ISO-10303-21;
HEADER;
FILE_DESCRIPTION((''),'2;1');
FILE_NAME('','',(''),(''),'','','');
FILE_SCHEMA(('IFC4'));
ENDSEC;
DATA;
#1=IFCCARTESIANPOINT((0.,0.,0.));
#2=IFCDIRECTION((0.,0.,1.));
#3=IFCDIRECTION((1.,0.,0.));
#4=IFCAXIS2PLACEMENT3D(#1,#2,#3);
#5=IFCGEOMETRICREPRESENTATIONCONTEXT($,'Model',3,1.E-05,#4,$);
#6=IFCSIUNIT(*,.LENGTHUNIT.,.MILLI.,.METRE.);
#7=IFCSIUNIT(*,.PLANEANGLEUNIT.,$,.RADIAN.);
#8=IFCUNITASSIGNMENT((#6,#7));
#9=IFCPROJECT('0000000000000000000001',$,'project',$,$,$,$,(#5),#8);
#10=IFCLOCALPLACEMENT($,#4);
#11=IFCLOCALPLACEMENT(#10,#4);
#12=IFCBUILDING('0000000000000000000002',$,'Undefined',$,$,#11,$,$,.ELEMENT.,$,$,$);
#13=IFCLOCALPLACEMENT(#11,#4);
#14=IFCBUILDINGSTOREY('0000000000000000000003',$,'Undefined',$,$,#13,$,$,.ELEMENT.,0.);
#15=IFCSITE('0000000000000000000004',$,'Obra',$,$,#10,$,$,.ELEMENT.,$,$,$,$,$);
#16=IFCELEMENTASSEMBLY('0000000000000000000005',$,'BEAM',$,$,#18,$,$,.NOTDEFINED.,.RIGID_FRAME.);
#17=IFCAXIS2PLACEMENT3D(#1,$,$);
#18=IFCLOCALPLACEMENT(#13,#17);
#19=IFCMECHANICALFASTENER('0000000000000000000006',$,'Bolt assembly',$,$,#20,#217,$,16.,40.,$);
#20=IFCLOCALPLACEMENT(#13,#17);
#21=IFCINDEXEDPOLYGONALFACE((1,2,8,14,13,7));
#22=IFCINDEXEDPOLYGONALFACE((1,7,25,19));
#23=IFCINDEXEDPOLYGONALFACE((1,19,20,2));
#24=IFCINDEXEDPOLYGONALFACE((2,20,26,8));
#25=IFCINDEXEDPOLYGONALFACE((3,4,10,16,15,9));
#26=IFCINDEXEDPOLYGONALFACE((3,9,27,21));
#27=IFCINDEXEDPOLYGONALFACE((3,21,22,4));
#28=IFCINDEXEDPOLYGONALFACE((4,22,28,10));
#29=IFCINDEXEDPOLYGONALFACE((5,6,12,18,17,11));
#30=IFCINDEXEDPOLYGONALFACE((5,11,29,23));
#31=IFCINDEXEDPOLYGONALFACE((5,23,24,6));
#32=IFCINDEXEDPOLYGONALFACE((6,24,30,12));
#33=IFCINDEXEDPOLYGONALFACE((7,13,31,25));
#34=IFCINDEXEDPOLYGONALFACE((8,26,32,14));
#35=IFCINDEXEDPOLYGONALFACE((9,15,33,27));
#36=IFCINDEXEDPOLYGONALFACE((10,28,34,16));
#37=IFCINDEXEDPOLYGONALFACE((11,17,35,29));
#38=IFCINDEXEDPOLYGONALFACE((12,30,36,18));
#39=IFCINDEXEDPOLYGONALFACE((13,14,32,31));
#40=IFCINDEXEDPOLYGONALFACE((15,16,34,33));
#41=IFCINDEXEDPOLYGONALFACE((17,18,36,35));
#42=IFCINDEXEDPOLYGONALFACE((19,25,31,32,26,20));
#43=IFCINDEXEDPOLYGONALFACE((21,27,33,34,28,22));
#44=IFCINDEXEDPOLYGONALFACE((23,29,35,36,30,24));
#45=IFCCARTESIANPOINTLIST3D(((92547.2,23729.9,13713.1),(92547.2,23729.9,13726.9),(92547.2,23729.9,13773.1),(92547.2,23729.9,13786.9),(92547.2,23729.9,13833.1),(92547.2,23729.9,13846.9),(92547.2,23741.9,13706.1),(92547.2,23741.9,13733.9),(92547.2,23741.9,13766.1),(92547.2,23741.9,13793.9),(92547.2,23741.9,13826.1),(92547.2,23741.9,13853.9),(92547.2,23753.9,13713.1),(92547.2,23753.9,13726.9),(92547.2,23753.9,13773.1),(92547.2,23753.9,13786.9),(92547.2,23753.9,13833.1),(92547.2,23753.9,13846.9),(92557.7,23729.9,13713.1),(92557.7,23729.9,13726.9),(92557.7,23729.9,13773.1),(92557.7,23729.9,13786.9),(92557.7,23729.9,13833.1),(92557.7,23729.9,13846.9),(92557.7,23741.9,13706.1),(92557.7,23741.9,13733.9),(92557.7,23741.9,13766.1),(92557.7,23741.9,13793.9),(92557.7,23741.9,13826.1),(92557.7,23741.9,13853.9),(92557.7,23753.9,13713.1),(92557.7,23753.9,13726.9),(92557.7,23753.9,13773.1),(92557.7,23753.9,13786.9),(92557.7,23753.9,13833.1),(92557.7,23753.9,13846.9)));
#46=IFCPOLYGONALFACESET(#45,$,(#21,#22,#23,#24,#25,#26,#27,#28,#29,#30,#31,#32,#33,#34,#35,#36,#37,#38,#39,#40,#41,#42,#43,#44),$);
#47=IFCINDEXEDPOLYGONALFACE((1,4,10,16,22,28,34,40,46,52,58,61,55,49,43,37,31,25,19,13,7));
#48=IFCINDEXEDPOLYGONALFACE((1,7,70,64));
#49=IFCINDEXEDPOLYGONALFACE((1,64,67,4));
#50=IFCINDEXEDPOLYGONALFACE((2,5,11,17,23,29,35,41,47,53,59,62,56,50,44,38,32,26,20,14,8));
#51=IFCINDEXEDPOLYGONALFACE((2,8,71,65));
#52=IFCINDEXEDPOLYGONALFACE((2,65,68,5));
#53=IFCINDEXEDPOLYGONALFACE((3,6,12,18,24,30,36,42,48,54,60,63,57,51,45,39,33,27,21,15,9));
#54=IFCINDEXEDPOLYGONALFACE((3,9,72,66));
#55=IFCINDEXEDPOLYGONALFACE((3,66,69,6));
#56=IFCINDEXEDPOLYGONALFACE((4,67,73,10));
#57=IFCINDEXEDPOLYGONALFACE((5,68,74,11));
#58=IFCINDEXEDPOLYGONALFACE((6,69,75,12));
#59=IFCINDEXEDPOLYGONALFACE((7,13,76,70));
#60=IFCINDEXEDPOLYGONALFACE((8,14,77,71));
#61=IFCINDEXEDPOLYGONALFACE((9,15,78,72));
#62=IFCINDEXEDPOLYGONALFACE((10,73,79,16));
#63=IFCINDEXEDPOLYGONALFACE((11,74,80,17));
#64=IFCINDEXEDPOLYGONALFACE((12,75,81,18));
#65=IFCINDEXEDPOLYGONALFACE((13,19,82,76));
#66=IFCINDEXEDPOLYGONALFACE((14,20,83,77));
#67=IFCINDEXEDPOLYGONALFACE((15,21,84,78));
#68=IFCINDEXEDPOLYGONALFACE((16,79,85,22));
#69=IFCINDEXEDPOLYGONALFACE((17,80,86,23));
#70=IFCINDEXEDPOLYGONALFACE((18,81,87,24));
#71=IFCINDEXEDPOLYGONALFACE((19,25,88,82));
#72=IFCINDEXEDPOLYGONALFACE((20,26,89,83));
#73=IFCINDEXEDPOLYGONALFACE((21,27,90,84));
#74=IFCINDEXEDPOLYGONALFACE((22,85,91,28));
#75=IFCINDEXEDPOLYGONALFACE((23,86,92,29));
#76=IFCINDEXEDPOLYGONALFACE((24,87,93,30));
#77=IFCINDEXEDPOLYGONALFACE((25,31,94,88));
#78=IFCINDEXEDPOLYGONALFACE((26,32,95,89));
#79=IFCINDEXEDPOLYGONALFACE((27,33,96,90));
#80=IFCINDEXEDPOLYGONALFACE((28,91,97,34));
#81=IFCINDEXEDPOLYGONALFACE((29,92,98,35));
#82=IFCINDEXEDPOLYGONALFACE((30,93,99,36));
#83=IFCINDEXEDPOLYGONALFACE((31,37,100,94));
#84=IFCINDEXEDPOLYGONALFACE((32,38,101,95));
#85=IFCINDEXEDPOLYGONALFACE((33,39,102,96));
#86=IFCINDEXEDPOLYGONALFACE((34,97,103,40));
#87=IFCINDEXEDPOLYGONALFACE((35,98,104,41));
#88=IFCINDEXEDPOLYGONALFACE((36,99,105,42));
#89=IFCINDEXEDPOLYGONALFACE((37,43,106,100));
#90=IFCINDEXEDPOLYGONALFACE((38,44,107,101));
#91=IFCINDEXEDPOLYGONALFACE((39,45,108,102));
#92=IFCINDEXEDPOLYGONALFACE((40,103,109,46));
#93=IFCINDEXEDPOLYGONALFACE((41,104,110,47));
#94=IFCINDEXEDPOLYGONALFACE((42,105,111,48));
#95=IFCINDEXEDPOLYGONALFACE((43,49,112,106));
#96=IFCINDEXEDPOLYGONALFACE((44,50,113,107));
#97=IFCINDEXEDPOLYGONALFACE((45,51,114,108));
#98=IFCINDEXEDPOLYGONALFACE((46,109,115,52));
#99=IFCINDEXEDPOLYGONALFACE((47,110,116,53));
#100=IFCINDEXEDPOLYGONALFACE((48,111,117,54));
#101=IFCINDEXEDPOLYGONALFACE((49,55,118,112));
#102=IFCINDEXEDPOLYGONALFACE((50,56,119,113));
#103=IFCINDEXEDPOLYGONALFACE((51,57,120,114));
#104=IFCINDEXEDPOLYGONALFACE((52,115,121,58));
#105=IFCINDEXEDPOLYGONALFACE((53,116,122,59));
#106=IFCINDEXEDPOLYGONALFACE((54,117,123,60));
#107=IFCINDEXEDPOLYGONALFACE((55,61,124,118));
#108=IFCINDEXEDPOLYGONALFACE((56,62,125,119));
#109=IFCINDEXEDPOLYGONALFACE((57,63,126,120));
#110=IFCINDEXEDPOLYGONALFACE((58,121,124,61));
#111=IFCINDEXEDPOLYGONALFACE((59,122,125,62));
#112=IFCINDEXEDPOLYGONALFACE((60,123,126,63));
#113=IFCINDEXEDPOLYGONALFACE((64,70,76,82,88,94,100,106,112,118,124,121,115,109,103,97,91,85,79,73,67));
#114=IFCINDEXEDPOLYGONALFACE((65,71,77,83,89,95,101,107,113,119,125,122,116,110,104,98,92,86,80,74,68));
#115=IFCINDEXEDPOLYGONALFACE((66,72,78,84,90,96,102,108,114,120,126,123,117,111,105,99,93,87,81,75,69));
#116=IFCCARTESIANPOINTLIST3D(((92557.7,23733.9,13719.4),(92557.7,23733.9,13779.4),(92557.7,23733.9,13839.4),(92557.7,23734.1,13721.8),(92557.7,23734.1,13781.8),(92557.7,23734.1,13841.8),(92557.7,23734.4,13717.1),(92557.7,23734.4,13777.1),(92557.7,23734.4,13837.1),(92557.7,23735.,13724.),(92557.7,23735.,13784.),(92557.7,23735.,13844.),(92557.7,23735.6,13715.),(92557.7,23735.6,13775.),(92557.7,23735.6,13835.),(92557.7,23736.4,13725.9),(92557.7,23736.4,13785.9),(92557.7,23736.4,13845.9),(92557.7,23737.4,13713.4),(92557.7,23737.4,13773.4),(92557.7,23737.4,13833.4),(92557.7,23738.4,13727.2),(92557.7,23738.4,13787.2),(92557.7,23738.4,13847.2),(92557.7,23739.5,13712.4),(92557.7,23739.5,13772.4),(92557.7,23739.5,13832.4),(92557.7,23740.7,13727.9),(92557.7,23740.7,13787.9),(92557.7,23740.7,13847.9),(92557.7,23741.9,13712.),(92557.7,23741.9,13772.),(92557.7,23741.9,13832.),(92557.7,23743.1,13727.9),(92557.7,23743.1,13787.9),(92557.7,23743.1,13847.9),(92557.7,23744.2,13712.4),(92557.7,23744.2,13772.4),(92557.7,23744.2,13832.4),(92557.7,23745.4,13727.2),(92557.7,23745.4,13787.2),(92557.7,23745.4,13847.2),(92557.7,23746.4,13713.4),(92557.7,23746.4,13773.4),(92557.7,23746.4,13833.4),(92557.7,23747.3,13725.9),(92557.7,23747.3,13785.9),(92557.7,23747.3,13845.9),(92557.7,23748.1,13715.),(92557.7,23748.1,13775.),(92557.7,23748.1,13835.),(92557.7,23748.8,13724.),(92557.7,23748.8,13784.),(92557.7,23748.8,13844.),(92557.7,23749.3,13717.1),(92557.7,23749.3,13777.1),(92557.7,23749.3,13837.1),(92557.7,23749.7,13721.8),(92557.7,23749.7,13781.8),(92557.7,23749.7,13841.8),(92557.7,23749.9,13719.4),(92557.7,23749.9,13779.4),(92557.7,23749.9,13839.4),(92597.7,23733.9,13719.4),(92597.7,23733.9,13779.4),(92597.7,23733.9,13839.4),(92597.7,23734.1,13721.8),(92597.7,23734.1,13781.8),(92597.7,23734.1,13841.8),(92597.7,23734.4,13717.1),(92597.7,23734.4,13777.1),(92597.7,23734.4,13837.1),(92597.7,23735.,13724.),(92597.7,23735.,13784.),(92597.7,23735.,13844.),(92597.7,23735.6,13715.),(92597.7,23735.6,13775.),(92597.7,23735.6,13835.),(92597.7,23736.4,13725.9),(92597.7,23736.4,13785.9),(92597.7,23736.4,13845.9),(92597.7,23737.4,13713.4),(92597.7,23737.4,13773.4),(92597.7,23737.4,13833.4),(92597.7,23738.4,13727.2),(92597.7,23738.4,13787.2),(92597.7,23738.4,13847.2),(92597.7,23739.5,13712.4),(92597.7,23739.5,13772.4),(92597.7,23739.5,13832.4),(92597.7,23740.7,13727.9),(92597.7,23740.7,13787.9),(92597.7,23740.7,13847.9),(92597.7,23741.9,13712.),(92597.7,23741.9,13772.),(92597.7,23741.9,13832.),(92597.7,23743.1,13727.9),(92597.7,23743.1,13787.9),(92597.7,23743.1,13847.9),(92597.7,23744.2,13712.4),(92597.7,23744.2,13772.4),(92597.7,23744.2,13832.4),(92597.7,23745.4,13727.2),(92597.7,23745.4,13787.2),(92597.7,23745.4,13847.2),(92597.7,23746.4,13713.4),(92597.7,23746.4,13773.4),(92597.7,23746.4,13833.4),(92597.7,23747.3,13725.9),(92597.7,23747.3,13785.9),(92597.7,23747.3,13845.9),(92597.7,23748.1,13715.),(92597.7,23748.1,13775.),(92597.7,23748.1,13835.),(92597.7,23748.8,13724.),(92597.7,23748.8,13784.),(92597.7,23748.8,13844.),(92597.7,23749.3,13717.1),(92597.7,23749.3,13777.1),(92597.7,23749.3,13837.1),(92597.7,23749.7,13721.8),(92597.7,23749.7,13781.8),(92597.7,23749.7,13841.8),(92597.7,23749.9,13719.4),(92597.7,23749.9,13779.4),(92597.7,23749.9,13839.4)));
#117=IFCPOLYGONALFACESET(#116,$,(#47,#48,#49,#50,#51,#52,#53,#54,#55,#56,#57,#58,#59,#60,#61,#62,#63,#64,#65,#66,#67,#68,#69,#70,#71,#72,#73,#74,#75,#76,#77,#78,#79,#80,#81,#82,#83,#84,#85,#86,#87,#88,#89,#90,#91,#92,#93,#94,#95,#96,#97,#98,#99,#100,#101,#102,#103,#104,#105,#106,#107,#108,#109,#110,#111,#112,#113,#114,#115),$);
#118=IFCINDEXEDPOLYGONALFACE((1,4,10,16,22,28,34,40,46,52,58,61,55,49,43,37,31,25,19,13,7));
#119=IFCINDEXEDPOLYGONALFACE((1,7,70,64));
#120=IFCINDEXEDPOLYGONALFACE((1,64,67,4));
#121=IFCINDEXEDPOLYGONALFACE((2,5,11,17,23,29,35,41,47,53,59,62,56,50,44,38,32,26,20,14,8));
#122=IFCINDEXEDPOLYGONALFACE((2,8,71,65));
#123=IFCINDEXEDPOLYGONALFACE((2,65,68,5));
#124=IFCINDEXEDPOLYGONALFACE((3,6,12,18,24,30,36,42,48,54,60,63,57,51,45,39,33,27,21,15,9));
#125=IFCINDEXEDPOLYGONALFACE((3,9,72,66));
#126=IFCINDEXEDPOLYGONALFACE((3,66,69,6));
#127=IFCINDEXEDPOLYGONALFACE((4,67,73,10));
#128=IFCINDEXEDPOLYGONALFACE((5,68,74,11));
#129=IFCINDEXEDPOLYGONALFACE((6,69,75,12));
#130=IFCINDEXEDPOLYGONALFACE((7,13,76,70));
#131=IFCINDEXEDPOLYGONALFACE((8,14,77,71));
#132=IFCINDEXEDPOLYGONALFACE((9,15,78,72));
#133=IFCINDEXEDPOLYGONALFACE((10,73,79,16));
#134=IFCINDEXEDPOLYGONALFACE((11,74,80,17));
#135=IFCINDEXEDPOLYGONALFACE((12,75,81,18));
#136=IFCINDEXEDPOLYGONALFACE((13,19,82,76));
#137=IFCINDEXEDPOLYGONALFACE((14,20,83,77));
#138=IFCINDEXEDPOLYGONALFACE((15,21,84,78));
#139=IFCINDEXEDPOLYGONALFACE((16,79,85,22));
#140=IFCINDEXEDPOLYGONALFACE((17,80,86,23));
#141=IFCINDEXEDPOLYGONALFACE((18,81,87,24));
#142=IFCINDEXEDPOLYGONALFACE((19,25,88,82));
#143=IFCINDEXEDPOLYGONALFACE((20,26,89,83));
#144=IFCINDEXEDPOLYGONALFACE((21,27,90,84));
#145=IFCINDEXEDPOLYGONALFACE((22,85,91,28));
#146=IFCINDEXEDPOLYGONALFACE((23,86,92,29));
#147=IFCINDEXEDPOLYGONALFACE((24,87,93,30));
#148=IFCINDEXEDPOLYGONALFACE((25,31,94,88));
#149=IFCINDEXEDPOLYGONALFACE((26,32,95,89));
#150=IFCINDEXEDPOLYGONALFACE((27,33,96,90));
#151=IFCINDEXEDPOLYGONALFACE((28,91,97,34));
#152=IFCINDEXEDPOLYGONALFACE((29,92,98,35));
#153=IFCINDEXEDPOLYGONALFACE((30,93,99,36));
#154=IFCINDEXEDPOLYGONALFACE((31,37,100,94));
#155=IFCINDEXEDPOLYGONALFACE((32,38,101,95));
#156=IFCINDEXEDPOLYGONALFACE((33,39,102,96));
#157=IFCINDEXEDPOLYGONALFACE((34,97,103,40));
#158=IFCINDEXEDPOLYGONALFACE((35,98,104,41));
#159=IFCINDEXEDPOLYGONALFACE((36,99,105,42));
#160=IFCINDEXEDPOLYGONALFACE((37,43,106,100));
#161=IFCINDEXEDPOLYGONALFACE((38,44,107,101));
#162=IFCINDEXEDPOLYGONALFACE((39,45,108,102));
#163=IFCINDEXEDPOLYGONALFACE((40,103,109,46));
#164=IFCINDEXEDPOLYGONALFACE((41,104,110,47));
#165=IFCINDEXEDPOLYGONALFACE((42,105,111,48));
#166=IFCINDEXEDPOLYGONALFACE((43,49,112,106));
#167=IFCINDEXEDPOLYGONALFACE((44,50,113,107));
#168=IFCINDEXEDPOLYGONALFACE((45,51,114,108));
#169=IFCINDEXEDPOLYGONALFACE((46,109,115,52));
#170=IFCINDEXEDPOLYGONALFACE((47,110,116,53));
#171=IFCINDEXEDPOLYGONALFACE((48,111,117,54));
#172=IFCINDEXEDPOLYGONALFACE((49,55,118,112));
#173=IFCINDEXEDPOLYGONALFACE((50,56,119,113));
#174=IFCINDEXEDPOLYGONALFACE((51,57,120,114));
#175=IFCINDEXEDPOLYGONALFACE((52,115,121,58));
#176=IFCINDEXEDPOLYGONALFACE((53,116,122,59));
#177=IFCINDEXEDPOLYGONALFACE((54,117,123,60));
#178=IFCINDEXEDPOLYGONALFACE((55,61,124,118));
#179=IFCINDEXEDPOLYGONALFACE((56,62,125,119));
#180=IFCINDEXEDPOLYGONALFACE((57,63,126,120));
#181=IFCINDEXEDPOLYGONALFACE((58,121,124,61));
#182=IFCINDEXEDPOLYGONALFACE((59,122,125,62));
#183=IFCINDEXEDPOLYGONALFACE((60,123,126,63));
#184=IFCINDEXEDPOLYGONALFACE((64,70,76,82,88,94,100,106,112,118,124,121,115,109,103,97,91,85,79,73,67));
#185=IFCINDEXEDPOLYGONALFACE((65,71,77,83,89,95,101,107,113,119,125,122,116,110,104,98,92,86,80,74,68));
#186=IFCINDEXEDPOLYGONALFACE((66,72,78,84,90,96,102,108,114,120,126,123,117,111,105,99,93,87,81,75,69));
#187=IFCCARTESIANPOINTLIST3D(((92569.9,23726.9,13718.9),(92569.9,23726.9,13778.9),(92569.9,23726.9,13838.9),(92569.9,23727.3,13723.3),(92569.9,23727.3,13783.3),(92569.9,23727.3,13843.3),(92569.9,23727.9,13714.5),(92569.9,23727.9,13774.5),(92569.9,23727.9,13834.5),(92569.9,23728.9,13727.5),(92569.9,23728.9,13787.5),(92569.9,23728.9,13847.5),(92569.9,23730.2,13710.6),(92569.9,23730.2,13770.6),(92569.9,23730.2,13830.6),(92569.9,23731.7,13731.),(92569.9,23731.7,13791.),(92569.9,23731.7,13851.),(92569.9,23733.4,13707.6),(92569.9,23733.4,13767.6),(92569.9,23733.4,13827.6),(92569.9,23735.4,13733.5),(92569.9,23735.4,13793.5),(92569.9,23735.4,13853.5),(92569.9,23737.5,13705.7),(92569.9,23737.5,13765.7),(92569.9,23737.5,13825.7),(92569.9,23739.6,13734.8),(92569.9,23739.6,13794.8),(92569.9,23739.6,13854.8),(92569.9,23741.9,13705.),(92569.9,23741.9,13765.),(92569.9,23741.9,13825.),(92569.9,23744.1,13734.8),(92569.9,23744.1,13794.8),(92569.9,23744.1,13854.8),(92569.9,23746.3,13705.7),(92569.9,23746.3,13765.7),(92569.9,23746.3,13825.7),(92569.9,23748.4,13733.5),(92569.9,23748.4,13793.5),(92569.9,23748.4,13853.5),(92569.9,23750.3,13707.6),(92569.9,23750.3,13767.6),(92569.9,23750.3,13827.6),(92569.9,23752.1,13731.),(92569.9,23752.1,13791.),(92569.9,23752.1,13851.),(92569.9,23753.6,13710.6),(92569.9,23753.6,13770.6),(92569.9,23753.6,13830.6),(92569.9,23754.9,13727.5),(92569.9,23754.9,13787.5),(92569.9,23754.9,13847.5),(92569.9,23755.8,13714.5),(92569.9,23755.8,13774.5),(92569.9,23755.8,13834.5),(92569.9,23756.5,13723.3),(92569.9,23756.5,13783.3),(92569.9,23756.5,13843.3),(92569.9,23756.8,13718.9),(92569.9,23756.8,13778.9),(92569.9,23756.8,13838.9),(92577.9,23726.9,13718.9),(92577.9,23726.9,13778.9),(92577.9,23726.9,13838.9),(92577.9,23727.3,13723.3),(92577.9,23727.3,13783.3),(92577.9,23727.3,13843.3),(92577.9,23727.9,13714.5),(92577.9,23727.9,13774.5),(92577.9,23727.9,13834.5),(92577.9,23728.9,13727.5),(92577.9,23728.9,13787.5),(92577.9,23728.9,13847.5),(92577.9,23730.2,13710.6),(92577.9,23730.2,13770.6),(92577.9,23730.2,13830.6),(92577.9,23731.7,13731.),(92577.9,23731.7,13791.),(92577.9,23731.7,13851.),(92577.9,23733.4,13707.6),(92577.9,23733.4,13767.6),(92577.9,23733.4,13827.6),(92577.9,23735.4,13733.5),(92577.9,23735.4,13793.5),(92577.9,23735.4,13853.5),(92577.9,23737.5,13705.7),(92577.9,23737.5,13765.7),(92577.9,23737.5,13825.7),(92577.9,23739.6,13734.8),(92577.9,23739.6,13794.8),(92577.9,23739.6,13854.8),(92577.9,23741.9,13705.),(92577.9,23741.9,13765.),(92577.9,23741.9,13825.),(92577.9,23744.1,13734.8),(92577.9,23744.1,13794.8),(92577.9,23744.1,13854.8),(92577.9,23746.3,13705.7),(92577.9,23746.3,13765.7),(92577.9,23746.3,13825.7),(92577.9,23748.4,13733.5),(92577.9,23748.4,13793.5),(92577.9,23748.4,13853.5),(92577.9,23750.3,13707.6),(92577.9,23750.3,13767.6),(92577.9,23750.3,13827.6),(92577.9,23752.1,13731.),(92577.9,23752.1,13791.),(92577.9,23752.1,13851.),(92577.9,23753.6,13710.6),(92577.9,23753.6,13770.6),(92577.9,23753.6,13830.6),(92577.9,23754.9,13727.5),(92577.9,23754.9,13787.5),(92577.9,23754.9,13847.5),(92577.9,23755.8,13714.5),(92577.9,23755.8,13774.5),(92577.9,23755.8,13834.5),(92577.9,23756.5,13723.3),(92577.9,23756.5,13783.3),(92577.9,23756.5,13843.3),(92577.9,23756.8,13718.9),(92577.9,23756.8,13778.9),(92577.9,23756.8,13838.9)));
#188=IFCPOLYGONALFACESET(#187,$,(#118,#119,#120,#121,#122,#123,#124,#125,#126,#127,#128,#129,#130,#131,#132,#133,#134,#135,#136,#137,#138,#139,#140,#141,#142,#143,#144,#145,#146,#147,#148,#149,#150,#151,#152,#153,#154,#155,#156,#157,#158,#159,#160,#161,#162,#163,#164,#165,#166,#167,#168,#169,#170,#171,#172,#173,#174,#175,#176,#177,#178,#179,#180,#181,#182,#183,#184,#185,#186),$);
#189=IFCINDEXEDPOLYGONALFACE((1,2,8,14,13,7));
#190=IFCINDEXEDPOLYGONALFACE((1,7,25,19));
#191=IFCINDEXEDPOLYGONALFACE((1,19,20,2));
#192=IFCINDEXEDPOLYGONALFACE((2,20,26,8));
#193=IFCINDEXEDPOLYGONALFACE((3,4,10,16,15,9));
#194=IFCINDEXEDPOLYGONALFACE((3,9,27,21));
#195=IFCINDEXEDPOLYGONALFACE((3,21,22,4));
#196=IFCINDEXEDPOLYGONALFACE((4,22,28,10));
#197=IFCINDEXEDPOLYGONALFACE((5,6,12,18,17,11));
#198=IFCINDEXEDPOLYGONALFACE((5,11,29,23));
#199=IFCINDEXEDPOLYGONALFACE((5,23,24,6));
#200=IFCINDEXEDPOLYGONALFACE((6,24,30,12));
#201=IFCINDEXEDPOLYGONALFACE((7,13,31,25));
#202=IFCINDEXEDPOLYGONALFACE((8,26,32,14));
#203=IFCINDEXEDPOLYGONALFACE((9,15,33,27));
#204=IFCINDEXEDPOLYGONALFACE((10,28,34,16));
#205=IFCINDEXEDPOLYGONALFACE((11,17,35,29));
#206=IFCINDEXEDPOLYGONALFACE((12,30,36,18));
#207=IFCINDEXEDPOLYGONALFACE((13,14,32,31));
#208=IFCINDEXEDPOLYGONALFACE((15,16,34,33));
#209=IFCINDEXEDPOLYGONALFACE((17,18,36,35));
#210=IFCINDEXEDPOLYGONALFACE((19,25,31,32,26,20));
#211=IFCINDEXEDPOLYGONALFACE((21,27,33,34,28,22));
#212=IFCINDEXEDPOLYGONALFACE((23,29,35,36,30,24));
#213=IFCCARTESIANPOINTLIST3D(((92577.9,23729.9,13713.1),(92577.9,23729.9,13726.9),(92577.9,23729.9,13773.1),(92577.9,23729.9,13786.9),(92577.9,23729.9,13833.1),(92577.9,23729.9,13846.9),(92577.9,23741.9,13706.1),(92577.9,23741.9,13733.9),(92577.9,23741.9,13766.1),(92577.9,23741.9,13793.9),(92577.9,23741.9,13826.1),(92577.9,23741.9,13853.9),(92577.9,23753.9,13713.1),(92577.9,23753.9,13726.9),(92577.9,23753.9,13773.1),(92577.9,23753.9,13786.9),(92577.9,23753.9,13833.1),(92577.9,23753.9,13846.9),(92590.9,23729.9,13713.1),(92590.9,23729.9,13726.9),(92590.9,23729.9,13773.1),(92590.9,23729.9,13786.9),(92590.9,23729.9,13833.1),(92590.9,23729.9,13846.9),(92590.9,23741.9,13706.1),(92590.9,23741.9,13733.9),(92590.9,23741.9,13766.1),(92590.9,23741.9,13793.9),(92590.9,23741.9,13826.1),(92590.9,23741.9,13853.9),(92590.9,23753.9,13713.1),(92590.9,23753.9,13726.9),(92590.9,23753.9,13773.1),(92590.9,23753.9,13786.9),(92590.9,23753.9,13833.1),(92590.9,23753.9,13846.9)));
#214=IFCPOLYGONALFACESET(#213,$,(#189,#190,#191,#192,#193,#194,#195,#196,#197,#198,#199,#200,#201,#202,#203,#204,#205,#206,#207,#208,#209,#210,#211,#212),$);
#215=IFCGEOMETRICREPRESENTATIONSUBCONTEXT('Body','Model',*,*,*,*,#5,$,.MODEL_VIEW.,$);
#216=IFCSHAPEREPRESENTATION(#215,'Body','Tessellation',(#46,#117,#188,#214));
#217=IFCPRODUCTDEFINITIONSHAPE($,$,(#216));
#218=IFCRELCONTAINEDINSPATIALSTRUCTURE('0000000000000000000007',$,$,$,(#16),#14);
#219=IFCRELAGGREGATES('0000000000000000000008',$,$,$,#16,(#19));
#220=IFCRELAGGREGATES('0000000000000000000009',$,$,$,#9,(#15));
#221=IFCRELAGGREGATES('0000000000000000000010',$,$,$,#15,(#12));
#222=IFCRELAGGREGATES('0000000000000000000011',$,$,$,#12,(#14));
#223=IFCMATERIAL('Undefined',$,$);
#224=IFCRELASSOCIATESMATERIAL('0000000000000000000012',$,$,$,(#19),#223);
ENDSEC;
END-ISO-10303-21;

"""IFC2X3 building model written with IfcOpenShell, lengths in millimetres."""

from ifc_helpers import new_model, si_unit, frame, origin_with_axes, origin_2d_with_axis, place, context, subcontext, project, spatial, polyline, circle, outline, extrude, source, transform, mapped, material, element, aggregate, save


model = new_model("IFC2X3")

# Units and contexts
model_context = context("Model", 3, precision=1e-05, world=origin_with_axes())
body_context = subcontext(model_context, "Body", "Model", "MODEL_VIEW")
ifc_project = project(units=[si_unit("LENGTHUNIT", "METRE", prefix="MILLI"), si_unit("PLANEANGLEUNIT", "RADIAN")], contexts=[model_context])

# Site, building, storey
site_placement = place(None, origin_with_axes())
site = spatial("IfcSite", under=ifc_project, at=site_placement, Name="Obra", CompositionType="ELEMENT")
building_placement = place(site_placement, origin_with_axes())
building = spatial("IfcBuilding", under=site, at=building_placement, Name="Undefined", CompositionType="ELEMENT")
storey_placement = place(building_placement, origin_with_axes())
storey = spatial("IfcBuildingStorey", under=building, at=storey_placement, Name="Undefined", CompositionType="ELEMENT", Elevation=0.0)

# Element assembly, mechanical fastener
assembly_1_placement = place(storey_placement, origin_with_axes())
assembly_1 = element("IfcElementAssembly", 1, at=assembly_1_placement, inside=storey, Name="BEAM", AssemblyPlace="NOTDEFINED", PredefinedType="RIGID_FRAME")
ifc_material_1 = material(Name="Undefined")
shared_shape_1 = source(origin_with_axes(), body_context, "Body", "SweptSolid", [
    extrude(outline(polyline([(13.9, 0.0), (6.9, 12.0), (-6.9, 12.0), (-13.9, 0.0), (-6.9, -12.0), (6.9, -12.0), (13.9, 0.0)])), frame((0.0, -19.7, 0.0), z_axis=(0.0, 1.0, 0.0), x_axis=(1.0, 0.0, 0.0)), (0.0, 0.0, 1.0), 10.6),
    extrude(circle(Radius=8.0, at=origin_2d_with_axis()), frame((0.0, -9.1, 0.0), z_axis=(0.0, 1.0, 0.0), x_axis=(1.0, 0.0, 0.0)), (0.0, 0.0, 1.0), 40.0),
    extrude(circle(Radius=15.0, at=origin_2d_with_axis()), frame((0.0, 3.1, 0.0), z_axis=(0.0, 1.0, 0.0), x_axis=(1.0, 0.0, 0.0)), (0.0, 0.0, 1.0), 8.0),
    extrude(outline(polyline([(13.9, 0.0), (6.9, 12.0), (-6.9, 12.0), (-13.9, 0.0), (-6.9, -12.0), (6.9, -12.0), (13.9, 0.0)])), frame((0.0, 11.1, 0.0), z_axis=(0.0, 1.0, 0.0), x_axis=(1.0, 0.0, 0.0)), (0.0, 0.0, 1.0), 13.0),
])
mechanical_fastener_1_placement = place(assembly_1_placement, frame((92566.8, 23791.9, 13885.4), z_axis=(0.0, -1.0, 0.0), x_axis=(0.0, 0.0, -1.0)))
mechanical_fastener_1 = element("IfcMechanicalFastener", 2, at=mechanical_fastener_1_placement, material=ifc_material_1, Name="Bolt assembly", NominalDiameter=16.0, NominalLength=40.0, context=body_context, shape_type="MappedRepresentation", body=[
    mapped(shared_shape_1, transform((165.4, 0.0, 50.0))),
    mapped(shared_shape_1, transform((105.4, 0.0, 50.0))),
    mapped(shared_shape_1, transform((45.4, 0.0, 50.0))),
])
aggregate(assembly_1, [mechanical_fastener_1])

save(model, "model.ifc")
